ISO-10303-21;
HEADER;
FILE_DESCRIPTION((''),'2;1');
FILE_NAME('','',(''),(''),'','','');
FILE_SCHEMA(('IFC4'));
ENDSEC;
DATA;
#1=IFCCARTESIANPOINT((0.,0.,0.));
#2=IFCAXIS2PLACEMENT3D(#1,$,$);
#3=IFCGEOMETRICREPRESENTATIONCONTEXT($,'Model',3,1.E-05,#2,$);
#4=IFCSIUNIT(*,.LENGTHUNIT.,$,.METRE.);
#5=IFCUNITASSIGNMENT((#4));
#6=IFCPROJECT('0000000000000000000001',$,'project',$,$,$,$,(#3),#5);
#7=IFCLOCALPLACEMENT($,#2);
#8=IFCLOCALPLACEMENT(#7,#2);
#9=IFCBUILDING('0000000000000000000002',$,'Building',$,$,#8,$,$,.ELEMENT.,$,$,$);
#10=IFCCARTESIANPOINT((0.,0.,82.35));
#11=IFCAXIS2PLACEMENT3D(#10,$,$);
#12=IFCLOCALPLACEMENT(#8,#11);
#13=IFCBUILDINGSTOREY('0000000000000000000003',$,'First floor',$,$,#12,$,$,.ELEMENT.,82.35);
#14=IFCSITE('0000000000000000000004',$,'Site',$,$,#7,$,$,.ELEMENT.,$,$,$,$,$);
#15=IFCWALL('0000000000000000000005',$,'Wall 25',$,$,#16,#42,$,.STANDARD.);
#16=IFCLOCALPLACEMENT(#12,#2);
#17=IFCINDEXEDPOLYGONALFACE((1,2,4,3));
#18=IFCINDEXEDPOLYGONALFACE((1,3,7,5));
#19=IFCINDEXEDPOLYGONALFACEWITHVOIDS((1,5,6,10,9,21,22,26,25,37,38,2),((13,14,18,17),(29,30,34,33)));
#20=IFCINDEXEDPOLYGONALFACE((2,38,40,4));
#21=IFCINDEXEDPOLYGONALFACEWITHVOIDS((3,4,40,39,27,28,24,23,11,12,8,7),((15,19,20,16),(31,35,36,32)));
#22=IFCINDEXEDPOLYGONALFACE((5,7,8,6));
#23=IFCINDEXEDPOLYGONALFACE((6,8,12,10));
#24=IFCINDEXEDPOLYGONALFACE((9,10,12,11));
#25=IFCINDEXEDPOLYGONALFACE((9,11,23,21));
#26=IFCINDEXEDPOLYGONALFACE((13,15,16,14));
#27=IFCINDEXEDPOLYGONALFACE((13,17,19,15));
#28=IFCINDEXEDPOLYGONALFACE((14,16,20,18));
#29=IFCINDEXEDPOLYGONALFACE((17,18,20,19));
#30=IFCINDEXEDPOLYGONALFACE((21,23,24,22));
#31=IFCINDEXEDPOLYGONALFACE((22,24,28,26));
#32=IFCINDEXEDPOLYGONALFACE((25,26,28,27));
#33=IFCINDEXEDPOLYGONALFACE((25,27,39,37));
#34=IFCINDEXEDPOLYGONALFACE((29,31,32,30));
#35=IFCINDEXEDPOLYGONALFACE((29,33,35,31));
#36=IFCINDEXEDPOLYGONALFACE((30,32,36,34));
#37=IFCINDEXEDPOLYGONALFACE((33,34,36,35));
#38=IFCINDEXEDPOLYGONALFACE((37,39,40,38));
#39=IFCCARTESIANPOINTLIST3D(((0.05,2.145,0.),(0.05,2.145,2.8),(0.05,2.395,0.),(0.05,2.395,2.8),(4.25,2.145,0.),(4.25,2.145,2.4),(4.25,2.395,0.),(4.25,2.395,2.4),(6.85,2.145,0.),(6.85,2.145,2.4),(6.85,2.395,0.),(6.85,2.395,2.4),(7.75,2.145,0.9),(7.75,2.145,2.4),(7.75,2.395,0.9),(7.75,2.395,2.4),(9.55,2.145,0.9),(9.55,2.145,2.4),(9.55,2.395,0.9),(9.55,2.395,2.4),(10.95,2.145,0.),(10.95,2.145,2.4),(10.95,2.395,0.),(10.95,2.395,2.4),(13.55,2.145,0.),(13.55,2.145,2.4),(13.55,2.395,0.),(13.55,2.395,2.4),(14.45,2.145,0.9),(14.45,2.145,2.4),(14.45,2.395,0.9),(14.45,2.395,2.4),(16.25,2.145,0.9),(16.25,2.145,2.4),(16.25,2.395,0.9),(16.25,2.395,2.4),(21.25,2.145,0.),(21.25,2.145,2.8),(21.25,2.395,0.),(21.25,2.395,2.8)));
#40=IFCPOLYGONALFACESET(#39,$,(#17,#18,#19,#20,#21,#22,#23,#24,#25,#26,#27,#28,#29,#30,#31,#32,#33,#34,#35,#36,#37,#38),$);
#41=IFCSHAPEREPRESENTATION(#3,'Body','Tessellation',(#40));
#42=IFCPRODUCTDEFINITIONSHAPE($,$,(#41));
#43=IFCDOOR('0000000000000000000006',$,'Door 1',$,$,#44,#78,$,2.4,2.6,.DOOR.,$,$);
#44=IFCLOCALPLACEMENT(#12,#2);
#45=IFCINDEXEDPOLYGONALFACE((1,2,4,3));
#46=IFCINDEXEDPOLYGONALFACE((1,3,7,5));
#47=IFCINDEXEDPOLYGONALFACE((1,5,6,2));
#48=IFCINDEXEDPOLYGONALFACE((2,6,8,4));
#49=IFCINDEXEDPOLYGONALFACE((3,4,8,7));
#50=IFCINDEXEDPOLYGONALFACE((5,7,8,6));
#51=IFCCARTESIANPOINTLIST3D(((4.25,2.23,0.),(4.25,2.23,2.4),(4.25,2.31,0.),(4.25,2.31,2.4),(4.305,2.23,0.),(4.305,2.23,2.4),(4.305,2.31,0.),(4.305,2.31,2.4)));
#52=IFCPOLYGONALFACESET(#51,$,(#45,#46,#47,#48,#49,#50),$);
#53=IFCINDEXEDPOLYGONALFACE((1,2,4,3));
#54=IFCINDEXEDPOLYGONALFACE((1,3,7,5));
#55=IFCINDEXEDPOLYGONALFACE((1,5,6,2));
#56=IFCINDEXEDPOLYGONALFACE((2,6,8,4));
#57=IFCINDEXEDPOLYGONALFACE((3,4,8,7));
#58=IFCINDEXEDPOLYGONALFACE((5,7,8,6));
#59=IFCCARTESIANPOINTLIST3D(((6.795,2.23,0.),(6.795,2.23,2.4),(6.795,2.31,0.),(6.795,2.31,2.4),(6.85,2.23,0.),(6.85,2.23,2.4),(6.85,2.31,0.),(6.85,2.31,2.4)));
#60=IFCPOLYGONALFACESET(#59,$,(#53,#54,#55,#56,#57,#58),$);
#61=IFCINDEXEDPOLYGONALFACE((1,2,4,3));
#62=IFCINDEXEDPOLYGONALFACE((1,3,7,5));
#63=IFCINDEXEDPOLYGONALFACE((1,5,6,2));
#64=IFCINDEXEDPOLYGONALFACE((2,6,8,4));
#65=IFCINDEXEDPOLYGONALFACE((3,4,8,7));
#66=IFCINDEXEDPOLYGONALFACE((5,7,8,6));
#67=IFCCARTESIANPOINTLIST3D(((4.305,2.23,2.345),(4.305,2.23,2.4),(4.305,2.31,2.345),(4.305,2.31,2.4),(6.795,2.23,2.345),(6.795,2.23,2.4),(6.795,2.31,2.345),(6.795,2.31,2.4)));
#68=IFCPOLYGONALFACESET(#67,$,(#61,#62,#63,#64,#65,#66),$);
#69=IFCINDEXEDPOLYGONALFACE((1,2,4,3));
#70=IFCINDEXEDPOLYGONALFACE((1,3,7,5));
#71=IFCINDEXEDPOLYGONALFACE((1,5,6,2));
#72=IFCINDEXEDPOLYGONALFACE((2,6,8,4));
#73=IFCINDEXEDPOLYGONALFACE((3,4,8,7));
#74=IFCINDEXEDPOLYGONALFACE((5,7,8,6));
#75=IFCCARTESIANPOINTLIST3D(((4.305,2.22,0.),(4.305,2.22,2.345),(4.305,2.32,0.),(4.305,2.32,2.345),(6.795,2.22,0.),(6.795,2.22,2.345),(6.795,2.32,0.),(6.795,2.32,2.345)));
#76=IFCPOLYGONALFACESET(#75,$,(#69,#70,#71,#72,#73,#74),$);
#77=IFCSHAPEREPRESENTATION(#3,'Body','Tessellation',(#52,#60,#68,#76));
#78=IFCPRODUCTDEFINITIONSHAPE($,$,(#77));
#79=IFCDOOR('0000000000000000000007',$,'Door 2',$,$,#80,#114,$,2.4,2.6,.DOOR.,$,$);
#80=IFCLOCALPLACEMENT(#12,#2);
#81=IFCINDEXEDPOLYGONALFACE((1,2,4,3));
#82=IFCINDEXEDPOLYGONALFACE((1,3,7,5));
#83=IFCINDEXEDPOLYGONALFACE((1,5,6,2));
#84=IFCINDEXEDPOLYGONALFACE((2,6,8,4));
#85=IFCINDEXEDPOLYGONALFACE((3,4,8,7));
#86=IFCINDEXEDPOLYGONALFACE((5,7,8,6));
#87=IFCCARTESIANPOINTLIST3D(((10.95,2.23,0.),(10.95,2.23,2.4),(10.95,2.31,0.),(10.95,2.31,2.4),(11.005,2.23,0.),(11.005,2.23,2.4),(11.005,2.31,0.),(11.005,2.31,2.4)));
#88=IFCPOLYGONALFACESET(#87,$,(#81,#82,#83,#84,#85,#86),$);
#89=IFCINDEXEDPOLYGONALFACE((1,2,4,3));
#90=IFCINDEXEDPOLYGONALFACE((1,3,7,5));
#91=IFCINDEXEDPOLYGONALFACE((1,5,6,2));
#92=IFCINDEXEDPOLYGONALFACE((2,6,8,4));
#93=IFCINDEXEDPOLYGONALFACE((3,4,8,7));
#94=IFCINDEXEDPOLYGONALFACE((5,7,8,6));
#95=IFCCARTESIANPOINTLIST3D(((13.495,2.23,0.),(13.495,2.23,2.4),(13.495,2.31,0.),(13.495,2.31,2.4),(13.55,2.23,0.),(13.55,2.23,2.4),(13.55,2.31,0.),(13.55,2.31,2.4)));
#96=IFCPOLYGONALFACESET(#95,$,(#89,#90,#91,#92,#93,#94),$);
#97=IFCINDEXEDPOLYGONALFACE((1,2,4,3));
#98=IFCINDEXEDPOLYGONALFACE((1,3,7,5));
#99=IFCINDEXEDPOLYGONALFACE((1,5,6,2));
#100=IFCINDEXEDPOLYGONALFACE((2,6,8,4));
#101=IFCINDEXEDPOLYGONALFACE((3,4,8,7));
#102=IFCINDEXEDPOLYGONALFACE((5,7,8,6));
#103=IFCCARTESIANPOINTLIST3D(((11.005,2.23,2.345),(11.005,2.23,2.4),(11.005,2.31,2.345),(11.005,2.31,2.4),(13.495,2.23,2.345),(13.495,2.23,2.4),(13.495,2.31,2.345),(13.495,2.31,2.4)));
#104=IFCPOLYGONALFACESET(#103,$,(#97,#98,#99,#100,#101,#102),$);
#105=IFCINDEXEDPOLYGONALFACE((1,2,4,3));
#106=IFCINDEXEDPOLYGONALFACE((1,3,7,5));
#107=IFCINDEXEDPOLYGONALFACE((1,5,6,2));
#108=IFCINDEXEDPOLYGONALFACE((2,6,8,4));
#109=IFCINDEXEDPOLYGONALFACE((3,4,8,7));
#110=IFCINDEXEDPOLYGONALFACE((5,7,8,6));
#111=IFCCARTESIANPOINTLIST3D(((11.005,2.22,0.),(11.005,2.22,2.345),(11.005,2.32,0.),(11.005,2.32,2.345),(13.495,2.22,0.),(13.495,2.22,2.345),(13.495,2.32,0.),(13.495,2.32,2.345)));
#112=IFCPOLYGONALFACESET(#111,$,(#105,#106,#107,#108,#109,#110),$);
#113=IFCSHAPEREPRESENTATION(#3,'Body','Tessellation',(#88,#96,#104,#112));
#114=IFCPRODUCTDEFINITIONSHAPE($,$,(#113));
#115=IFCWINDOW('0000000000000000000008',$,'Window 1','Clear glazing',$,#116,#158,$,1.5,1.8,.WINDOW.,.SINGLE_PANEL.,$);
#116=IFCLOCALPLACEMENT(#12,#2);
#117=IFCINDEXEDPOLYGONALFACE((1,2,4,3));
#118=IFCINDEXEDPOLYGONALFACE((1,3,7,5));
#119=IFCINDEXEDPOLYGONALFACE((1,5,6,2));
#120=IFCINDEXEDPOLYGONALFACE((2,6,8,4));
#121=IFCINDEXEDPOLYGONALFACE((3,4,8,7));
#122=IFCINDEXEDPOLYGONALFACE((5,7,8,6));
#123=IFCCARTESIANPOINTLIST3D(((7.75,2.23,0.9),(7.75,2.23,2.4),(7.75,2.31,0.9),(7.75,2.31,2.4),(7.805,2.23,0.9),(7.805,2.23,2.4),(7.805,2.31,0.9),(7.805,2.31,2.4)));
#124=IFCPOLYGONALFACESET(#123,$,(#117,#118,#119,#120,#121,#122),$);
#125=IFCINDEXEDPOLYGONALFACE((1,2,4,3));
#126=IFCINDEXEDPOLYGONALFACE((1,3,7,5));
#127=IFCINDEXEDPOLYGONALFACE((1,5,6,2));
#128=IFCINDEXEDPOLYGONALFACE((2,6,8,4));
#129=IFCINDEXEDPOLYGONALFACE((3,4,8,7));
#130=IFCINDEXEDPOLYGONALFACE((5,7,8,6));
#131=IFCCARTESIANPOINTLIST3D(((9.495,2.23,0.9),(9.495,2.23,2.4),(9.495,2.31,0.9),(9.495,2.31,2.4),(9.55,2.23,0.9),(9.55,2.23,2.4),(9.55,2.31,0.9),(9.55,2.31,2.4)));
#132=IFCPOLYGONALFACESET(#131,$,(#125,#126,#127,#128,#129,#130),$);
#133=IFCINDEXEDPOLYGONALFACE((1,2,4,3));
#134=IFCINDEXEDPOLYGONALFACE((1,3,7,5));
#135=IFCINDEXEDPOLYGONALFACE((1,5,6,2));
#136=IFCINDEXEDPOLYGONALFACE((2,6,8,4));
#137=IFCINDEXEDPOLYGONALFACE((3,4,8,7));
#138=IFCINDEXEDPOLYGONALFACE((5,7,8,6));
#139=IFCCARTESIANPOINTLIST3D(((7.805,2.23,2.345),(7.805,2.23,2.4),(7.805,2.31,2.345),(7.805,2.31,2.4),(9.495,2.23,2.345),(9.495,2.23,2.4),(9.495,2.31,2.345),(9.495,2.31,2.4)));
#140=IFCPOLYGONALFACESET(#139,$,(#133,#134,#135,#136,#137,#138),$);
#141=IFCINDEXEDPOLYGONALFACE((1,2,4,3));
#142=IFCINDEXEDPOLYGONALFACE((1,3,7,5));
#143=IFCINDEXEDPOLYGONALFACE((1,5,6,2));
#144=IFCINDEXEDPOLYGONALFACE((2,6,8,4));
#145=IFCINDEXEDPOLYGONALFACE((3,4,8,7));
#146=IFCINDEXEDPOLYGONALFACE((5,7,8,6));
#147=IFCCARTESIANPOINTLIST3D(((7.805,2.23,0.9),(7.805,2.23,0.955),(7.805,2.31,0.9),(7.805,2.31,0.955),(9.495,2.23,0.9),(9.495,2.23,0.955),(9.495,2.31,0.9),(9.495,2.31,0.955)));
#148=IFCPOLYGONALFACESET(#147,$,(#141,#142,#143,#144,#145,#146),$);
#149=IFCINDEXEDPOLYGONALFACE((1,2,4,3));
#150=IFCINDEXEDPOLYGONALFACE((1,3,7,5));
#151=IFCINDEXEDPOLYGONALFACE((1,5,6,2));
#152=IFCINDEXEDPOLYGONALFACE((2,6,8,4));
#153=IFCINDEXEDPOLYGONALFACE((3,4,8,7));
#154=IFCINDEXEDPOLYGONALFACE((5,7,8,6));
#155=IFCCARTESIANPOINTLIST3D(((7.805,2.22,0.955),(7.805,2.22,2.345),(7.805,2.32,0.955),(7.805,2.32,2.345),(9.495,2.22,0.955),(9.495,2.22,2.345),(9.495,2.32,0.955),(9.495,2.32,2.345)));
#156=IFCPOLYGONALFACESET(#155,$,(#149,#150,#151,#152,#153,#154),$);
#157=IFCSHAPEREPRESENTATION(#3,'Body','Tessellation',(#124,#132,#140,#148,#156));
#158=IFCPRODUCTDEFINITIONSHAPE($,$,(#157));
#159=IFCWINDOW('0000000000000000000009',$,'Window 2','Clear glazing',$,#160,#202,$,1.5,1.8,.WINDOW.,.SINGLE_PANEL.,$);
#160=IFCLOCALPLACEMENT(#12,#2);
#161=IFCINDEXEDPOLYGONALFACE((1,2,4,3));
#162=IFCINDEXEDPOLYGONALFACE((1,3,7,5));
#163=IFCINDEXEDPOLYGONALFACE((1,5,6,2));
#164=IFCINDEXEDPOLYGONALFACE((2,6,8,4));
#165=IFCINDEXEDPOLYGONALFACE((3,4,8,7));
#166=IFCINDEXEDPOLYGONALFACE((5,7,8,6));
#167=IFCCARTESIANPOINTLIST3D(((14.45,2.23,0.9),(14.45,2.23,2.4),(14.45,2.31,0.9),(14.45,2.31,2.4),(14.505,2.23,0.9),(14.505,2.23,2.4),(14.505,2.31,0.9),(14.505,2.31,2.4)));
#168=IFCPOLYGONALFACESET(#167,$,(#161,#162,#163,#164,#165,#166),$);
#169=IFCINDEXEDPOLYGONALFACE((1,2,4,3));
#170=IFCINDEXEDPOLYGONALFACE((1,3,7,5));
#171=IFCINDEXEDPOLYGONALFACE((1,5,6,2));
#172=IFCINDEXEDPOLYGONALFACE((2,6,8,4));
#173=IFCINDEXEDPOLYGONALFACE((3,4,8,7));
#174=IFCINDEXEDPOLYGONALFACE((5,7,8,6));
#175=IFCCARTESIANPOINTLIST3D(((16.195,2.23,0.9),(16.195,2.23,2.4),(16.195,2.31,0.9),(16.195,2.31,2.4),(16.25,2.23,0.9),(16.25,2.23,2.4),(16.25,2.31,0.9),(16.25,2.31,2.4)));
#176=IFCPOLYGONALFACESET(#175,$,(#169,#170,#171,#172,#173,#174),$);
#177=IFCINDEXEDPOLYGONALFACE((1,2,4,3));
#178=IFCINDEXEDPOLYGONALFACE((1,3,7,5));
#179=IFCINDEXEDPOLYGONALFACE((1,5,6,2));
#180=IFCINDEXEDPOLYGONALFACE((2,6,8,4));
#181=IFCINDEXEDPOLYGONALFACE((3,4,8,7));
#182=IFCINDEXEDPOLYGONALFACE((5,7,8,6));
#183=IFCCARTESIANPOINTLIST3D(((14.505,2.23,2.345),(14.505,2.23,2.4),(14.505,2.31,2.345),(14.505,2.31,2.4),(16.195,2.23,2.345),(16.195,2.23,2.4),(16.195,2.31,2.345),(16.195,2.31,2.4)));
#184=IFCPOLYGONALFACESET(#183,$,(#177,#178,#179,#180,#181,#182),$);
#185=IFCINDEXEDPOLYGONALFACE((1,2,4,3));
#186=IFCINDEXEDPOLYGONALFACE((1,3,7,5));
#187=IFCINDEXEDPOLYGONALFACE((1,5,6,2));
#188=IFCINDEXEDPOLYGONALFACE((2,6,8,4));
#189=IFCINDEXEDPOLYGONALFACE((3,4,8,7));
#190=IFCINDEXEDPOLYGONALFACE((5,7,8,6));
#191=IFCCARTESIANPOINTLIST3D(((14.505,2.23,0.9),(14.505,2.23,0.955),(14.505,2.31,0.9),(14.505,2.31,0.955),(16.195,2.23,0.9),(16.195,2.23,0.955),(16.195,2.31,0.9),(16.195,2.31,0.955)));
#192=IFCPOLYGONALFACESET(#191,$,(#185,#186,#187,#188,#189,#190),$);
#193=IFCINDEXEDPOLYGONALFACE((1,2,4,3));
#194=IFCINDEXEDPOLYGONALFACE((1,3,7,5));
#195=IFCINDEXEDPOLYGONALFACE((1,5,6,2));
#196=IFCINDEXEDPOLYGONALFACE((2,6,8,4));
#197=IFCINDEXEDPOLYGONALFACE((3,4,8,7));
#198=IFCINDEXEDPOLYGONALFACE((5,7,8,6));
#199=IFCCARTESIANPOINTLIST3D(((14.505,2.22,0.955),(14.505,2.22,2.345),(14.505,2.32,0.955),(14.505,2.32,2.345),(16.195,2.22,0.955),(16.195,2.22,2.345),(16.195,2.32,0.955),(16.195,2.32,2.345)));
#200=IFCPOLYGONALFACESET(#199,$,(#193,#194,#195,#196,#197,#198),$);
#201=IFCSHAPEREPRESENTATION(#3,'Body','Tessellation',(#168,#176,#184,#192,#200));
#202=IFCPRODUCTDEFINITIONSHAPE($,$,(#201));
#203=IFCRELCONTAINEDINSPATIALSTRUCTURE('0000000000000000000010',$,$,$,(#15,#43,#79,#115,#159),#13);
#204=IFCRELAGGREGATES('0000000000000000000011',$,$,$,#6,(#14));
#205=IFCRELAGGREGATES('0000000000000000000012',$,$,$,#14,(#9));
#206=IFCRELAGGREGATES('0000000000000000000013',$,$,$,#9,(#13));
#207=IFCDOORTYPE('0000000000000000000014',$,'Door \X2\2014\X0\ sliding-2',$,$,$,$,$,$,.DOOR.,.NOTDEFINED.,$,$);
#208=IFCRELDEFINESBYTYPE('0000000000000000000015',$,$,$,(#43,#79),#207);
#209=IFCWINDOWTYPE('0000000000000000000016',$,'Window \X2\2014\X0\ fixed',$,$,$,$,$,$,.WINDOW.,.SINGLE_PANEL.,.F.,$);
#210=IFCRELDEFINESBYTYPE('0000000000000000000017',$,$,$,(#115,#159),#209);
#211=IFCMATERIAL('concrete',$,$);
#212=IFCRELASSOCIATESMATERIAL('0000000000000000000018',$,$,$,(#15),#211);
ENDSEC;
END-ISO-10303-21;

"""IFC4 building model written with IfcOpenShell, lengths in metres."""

from ifc_helpers import new_model, si_unit, frame, frame_2d, origin, place, context, project, spatial, rectangle, extrude, material, type_object, element, fill, save


model = new_model("IFC4")

# Units and contexts
model_context = context("Model", 3, precision=1e-05, world=origin())
ifc_project = project(units=[si_unit("LENGTHUNIT", "METRE")], contexts=[model_context])

# Site, building, storey
site_placement = place(None, origin())
site = spatial("IfcSite", under=ifc_project, at=site_placement, Name="Site", CompositionType="ELEMENT")
building_placement = place(site_placement, origin())
building = spatial("IfcBuilding", under=site, at=building_placement, Name="Building", CompositionType="ELEMENT")
storey_placement = place(building_placement, frame((0.0, 0.0, 82.35)))
storey = spatial("IfcBuildingStorey", under=building, at=storey_placement, Name="First floor", CompositionType="ELEMENT", Elevation=82.35)

# Shared definitions
ifc_material = material(Name="concrete")

# Wall, openings, doors, windows
wall_1_placement = place(storey_placement, frame((0.05, 2.27, 0.0), z_axis=(0.0, 0.0, 1.0), x_axis=(1.0, 0.0, 0.0)))
wall_1 = element("IfcWall", 1, at=wall_1_placement, inside=storey, material=ifc_material, Name="Wall 25", PredefinedType="STANDARD", context=model_context, shape_type="SweptSolid", body=[
    extrude(rectangle(XDim=21.2, YDim=0.25, at=frame_2d((10.6, 0.0))), origin(), (0.0, 0.0, 1.0), 2.8),
])
opening_1_placement = place(storey_placement, frame((4.25, 2.27, 0.0), z_axis=(0.0, 0.0, 1.0), x_axis=(1.0, 0.0, 0.0)))
opening_1 = element("IfcOpeningElement", 2, at=opening_1_placement, cuts=wall_1, PredefinedType="OPENING", context=model_context, shape_type="SweptSolid", body=[
    extrude(rectangle(XDim=2.6, YDim=0.31, at=frame_2d((1.3, 0.0))), origin(), (0.0, 0.0, 1.0), 2.4),
])
opening_2_placement = place(storey_placement, frame((7.75, 2.27, 0.9), z_axis=(0.0, 0.0, 1.0), x_axis=(1.0, 0.0, 0.0)))
opening_2 = element("IfcOpeningElement", 3, at=opening_2_placement, cuts=wall_1, PredefinedType="OPENING", context=model_context, shape_type="SweptSolid", body=[
    extrude(rectangle(XDim=1.8, YDim=0.31, at=frame_2d((0.9, 0.0))), origin(), (0.0, 0.0, 1.0), 1.5),
])
opening_3_placement = place(storey_placement, frame((10.95, 2.27, 0.0), z_axis=(0.0, 0.0, 1.0), x_axis=(1.0, 0.0, 0.0)))
opening_3 = element("IfcOpeningElement", 4, at=opening_3_placement, cuts=wall_1, PredefinedType="OPENING", context=model_context, shape_type="SweptSolid", body=[
    extrude(rectangle(XDim=2.6, YDim=0.31, at=frame_2d((1.3, 0.0))), origin(), (0.0, 0.0, 1.0), 2.4),
])
opening_4_placement = place(storey_placement, frame((14.45, 2.27, 0.9), z_axis=(0.0, 0.0, 1.0), x_axis=(1.0, 0.0, 0.0)))
opening_4 = element("IfcOpeningElement", 5, at=opening_4_placement, cuts=wall_1, PredefinedType="OPENING", context=model_context, shape_type="SweptSolid", body=[
    extrude(rectangle(XDim=1.8, YDim=0.31, at=frame_2d((0.9, 0.0))), origin(), (0.0, 0.0, 1.0), 1.5),
])
door_type = type_object("IfcDoorType", Name="Door — sliding-2", PredefinedType="DOOR")
door_1_placement = place(storey_placement, frame((4.25, 2.27, 0.0), z_axis=(0.0, 0.0, 1.0), x_axis=(1.0, 0.0, 0.0)))
door_1 = element("IfcDoor", 6, at=door_1_placement, inside=storey, type_object=door_type, Name="Door 1", OverallHeight=2.4, OverallWidth=2.6, PredefinedType="DOOR", context=model_context, shape_type="SweptSolid", body=[
    extrude(rectangle(XDim=0.055, YDim=0.08, at=frame_2d((0.0275, 0.0))), origin(), (0.0, 0.0, 1.0), 2.4),
    extrude(rectangle(XDim=0.055, YDim=0.08, at=frame_2d((2.5725, 0.0))), origin(), (0.0, 0.0, 1.0), 2.4),
    extrude(rectangle(XDim=2.49, YDim=0.08, at=frame_2d((1.3, 0.0))), frame((0.0, 0.0, 2.345)), (0.0, 0.0, 1.0), 0.055),
    extrude(rectangle(XDim=2.49, YDim=0.1, at=frame_2d((1.3, 0.0))), origin(), (0.0, 0.0, 1.0), 2.345),
])
fill(opening_1, door_1)
door_2_placement = place(storey_placement, frame((10.95, 2.27, 0.0), z_axis=(0.0, 0.0, 1.0), x_axis=(1.0, 0.0, 0.0)))
door_2 = element("IfcDoor", 7, at=door_2_placement, inside=storey, type_object=door_type, Name="Door 2", OverallHeight=2.4, OverallWidth=2.6, PredefinedType="DOOR", context=model_context, shape_type="SweptSolid", body=[
    extrude(rectangle(XDim=0.055, YDim=0.08, at=frame_2d((0.0275, 0.0))), origin(), (0.0, 0.0, 1.0), 2.4),
    extrude(rectangle(XDim=0.055, YDim=0.08, at=frame_2d((2.5725, 0.0))), origin(), (0.0, 0.0, 1.0), 2.4),
    extrude(rectangle(XDim=2.49, YDim=0.08, at=frame_2d((1.3, 0.0))), frame((0.0, 0.0, 2.345)), (0.0, 0.0, 1.0), 0.055),
    extrude(rectangle(XDim=2.49, YDim=0.1, at=frame_2d((1.3, 0.0))), origin(), (0.0, 0.0, 1.0), 2.345),
])
fill(opening_3, door_2)
window_type = type_object("IfcWindowType", Name="Window — fixed", ParameterTakesPrecedence=False, PartitioningType="SINGLE_PANEL", PredefinedType="WINDOW")
window_1_placement = place(storey_placement, frame((7.75, 2.27, 0.9), z_axis=(0.0, 0.0, 1.0), x_axis=(1.0, 0.0, 0.0)))
window_1 = element("IfcWindow", 8, at=window_1_placement, inside=storey, type_object=window_type, Name="Window 1", Description="Clear glazing", OverallHeight=1.5, OverallWidth=1.8, PartitioningType="SINGLE_PANEL", PredefinedType="WINDOW", context=model_context, shape_type="SweptSolid", body=[
    extrude(rectangle(XDim=0.055, YDim=0.08, at=frame_2d((0.0275, 0.0))), origin(), (0.0, 0.0, 1.0), 1.5),
    extrude(rectangle(XDim=0.055, YDim=0.08, at=frame_2d((1.7725, 0.0))), origin(), (0.0, 0.0, 1.0), 1.5),
    extrude(rectangle(XDim=1.69, YDim=0.08, at=frame_2d((0.9, 0.0))), frame((0.0, 0.0, 1.445)), (0.0, 0.0, 1.0), 0.055),
    extrude(rectangle(XDim=1.69, YDim=0.08, at=frame_2d((0.9, 0.0))), origin(), (0.0, 0.0, 1.0), 0.055),
    extrude(rectangle(XDim=1.69, YDim=0.1, at=frame_2d((0.9, 0.0))), frame((0.0, 0.0, 0.055)), (0.0, 0.0, 1.0), 1.39),
])
fill(opening_2, window_1)
window_2_placement = place(storey_placement, frame((14.45, 2.27, 0.9), z_axis=(0.0, 0.0, 1.0), x_axis=(1.0, 0.0, 0.0)))
window_2 = element("IfcWindow", 9, at=window_2_placement, inside=storey, type_object=window_type, Name="Window 2", Description="Clear glazing", OverallHeight=1.5, OverallWidth=1.8, PartitioningType="SINGLE_PANEL", PredefinedType="WINDOW", context=model_context, shape_type="SweptSolid", body=[
    extrude(rectangle(XDim=0.055, YDim=0.08, at=frame_2d((0.0275, 0.0))), origin(), (0.0, 0.0, 1.0), 1.5),
    extrude(rectangle(XDim=0.055, YDim=0.08, at=frame_2d((1.7725, 0.0))), origin(), (0.0, 0.0, 1.0), 1.5),
    extrude(rectangle(XDim=1.69, YDim=0.08, at=frame_2d((0.9, 0.0))), frame((0.0, 0.0, 1.445)), (0.0, 0.0, 1.0), 0.055),
    extrude(rectangle(XDim=1.69, YDim=0.08, at=frame_2d((0.9, 0.0))), origin(), (0.0, 0.0, 1.0), 0.055),
    extrude(rectangle(XDim=1.69, YDim=0.1, at=frame_2d((0.9, 0.0))), frame((0.0, 0.0, 0.055)), (0.0, 0.0, 1.0), 1.39),
])
fill(opening_4, window_2)

save(model, "model.ifc")
